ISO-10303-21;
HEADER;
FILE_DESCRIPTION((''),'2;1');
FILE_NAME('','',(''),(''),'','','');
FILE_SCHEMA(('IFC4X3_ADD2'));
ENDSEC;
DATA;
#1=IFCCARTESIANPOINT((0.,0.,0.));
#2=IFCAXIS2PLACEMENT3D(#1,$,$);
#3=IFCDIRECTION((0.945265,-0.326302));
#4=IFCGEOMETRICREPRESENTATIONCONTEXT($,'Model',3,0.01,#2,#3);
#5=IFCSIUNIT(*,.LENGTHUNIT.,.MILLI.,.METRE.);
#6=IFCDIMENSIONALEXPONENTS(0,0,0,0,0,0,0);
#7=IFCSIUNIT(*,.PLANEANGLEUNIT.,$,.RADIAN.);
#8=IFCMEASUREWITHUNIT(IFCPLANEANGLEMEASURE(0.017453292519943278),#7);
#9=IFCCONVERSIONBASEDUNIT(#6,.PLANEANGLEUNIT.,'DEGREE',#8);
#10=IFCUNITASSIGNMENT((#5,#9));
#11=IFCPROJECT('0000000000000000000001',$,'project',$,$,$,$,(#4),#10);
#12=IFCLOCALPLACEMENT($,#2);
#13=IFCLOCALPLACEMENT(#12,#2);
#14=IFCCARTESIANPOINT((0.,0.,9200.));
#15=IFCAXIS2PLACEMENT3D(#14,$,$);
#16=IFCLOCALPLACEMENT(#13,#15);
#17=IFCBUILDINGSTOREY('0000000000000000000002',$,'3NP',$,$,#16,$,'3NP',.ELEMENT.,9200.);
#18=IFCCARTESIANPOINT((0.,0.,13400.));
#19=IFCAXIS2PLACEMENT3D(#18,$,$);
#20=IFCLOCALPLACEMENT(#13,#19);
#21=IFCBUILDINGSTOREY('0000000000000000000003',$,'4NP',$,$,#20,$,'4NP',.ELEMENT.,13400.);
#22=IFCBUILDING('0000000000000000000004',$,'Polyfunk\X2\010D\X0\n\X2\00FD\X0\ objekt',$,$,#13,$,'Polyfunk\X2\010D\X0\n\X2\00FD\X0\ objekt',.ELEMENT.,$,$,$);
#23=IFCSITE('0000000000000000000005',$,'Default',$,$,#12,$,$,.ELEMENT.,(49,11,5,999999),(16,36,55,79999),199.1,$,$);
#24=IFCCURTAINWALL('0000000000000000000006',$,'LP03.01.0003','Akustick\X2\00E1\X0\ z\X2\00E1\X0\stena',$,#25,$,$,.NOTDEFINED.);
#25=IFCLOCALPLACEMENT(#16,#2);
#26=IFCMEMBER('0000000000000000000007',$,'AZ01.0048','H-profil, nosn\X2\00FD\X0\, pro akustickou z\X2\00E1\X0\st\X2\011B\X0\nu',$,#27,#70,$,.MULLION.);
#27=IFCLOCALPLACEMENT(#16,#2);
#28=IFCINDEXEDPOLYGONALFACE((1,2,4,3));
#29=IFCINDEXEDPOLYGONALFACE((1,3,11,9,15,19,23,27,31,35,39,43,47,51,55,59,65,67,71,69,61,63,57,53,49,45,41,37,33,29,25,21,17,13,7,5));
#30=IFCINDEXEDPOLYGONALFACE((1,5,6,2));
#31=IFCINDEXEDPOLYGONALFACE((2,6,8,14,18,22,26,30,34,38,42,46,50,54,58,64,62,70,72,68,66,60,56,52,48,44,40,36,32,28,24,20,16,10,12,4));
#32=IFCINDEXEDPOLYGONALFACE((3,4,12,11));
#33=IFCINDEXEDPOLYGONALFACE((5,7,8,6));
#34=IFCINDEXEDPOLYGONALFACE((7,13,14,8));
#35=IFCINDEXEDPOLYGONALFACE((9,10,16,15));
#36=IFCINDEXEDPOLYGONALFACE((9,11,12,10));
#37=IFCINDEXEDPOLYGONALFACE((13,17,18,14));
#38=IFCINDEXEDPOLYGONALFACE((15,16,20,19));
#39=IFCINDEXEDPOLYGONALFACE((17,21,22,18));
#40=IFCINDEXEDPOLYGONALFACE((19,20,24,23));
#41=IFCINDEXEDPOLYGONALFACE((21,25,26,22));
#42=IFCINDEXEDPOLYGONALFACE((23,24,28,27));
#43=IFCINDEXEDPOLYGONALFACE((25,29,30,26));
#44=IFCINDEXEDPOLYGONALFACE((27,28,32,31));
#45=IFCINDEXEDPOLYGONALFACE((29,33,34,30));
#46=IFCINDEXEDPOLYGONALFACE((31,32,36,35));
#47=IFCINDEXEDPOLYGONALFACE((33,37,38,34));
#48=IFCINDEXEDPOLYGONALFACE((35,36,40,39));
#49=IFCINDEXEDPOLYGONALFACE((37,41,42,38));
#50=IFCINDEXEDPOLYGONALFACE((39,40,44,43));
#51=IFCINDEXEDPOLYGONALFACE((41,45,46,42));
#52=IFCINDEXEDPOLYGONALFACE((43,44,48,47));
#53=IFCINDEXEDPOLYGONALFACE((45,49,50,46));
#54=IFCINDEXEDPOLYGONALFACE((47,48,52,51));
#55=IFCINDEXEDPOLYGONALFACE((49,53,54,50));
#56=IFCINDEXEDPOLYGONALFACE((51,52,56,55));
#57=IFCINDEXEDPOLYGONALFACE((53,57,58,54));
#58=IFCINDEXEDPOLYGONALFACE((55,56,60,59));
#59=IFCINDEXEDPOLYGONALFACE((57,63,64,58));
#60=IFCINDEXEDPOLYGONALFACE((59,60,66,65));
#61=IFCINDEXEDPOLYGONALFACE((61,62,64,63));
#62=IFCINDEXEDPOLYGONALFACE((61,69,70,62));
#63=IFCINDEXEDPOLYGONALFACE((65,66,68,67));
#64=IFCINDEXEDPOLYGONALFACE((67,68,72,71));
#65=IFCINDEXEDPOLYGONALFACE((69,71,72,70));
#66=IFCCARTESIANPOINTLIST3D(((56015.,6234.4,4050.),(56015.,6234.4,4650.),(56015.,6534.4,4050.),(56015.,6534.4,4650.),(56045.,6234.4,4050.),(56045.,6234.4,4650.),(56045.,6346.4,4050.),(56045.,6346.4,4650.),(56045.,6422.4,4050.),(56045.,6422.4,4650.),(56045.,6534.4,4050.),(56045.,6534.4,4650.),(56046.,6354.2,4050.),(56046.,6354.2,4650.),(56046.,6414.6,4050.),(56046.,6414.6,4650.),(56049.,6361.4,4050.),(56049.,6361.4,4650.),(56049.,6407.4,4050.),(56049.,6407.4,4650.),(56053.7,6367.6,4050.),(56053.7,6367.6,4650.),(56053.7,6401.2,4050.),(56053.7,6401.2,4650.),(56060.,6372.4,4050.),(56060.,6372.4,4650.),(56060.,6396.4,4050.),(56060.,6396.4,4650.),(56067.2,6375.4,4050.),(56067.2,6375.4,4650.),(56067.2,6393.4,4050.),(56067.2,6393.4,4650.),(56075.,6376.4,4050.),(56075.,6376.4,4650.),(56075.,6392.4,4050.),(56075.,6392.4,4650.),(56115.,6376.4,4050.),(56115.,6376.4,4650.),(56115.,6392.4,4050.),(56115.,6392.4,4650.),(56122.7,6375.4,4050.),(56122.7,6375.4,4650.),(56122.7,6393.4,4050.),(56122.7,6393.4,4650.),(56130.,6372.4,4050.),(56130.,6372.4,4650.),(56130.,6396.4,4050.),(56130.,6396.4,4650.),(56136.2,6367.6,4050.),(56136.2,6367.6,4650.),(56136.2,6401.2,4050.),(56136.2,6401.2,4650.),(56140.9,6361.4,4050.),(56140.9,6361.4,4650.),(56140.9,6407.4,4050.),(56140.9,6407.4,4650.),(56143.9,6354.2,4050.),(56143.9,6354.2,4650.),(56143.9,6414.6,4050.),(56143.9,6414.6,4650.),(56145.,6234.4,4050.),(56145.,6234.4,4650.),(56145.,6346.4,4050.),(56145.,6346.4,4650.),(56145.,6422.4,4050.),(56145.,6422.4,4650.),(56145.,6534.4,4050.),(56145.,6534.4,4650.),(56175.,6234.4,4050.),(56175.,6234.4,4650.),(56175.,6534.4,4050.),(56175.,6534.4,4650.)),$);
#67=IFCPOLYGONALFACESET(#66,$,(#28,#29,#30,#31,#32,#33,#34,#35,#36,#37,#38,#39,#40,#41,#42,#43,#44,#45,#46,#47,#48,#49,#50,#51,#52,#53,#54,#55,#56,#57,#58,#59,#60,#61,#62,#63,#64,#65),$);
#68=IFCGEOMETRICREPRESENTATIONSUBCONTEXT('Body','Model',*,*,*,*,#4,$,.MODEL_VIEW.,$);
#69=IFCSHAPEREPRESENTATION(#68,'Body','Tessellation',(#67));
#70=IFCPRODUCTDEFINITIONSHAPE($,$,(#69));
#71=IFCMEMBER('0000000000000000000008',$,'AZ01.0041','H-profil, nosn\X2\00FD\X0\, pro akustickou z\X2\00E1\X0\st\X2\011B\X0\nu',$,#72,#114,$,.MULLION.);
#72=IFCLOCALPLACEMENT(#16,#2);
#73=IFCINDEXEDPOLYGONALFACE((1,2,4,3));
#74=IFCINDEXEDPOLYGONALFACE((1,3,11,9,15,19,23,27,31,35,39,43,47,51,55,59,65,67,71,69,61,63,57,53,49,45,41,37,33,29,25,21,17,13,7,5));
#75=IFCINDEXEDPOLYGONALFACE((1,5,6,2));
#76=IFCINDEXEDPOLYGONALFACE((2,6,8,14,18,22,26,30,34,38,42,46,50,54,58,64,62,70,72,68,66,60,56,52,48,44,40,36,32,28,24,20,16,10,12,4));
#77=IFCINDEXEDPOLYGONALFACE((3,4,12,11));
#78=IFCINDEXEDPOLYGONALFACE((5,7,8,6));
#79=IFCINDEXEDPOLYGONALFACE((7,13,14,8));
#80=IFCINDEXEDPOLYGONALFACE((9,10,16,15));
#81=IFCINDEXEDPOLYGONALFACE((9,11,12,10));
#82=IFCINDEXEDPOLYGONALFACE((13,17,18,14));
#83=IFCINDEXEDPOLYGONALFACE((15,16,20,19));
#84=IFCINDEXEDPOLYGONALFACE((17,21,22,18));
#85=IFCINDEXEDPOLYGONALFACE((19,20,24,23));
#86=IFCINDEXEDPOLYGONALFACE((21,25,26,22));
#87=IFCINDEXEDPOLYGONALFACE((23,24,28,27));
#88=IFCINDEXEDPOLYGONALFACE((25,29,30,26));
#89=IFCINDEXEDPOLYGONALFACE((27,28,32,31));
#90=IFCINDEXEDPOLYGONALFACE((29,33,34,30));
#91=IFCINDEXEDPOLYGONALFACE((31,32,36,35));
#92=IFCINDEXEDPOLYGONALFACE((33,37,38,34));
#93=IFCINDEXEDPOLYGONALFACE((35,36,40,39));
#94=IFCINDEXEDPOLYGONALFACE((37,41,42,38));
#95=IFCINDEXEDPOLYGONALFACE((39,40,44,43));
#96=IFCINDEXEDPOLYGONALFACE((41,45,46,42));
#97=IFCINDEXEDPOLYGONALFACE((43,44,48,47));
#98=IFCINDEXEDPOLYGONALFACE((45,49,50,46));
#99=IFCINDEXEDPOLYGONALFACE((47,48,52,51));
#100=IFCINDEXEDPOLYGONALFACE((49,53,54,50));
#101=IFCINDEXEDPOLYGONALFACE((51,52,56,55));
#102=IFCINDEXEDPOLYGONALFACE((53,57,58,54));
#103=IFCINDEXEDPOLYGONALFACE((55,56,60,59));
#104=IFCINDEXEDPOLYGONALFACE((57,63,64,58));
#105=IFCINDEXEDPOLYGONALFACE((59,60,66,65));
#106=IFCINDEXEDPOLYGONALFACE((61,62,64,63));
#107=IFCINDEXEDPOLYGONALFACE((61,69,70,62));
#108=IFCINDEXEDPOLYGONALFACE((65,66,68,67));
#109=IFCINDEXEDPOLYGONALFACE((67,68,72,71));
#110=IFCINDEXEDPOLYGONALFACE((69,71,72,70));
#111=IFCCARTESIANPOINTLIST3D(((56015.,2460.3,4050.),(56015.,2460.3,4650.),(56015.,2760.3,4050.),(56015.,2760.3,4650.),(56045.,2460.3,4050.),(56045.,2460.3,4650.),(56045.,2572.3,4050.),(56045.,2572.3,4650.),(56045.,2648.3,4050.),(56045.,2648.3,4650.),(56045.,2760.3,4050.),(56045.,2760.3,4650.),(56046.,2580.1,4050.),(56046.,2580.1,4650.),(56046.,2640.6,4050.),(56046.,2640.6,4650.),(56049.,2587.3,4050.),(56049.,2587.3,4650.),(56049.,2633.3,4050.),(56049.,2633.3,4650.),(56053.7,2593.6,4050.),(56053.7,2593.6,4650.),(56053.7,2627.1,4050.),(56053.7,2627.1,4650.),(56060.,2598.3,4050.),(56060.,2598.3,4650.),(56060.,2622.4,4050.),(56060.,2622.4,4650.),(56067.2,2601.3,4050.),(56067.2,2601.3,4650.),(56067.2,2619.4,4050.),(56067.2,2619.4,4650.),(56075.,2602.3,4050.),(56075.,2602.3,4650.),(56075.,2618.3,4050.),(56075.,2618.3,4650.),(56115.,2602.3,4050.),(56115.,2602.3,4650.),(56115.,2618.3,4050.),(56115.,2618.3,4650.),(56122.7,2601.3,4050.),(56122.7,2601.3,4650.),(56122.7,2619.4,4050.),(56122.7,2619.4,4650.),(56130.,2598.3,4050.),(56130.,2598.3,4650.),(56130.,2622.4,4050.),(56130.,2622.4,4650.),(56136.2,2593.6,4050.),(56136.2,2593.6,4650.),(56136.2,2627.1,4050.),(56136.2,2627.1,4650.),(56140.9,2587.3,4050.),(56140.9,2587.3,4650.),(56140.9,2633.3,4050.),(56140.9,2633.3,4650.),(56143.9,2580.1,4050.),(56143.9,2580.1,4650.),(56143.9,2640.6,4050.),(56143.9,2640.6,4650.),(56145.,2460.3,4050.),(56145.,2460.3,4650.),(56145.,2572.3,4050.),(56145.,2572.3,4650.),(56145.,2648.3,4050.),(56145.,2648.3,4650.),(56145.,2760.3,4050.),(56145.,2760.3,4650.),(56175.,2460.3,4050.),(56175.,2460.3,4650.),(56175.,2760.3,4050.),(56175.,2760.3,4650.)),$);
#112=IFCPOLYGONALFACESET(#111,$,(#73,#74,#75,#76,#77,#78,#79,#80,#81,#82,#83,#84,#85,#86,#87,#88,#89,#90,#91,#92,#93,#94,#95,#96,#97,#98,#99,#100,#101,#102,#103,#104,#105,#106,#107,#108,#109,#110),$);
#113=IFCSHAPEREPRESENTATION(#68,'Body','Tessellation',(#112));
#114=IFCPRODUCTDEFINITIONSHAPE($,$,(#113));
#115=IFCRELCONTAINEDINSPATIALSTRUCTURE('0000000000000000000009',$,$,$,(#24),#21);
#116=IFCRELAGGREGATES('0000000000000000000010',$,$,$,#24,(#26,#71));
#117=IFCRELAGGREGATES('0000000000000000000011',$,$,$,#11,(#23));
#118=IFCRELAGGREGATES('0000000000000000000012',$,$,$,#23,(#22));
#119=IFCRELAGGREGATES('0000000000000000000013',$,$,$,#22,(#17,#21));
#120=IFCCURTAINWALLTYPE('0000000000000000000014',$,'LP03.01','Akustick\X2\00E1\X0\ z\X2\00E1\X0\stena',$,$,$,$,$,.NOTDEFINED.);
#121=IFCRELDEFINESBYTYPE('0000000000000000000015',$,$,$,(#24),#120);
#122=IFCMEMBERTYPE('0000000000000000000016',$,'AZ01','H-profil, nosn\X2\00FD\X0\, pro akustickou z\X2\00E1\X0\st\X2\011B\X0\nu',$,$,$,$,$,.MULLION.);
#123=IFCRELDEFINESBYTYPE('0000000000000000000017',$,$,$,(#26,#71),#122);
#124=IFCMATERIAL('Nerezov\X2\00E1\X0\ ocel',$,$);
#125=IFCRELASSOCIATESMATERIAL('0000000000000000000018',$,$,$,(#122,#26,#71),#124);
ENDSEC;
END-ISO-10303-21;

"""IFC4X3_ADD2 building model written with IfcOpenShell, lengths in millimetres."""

from ifc_helpers import new_model, entity, si_unit, converted_unit, direction, frame, frame_2d, origin, place, context, subcontext, project, spatial, polyline, circle_curve, parameter, trimmed, segment, composite_curve, outline, extrude, source, transform, mapped, material, material_profile, profile_set, profile_usage, type_object, element, aggregate, save


model = new_model("IFC4X3_ADD2")

# Units and contexts
model_context = context("Model", 3, precision=0.01, world=origin(), true_north=direction((0.945265, -0.326302)))
body_context = subcontext(model_context, "Body", "Model", "MODEL_VIEW")
ifc_project = project(units=[si_unit("LENGTHUNIT", "METRE", prefix="MILLI"), converted_unit("PLANEANGLEUNIT", "DEGREE", entity("IfcPlaneAngleMeasure", 0.017453292519943278), si_unit("PLANEANGLEUNIT", "RADIAN"), dimensions=[0, 0, 0, 0, 0, 0, 0])], contexts=[model_context])

# Site, building, storey
site_placement = place(None, origin())
site = spatial("IfcSite", under=ifc_project, at=site_placement, Name="Default", CompositionType="ELEMENT", RefLatitude=(49, 11, 5, 999999), RefLongitude=(16, 36, 55, 79999), RefElevation=199.1)
building_placement = place(site_placement, origin())
building = spatial("IfcBuilding", under=site, at=building_placement, Name="Polyfunkčný objekt", LongName="Polyfunkčný objekt", CompositionType="ELEMENT")
storey_1_placement = place(building_placement, frame((0.0, 0.0, 9200.0)))
storey_1 = spatial("IfcBuildingStorey", under=building, at=storey_1_placement, Name="3NP", LongName="3NP", CompositionType="ELEMENT", Elevation=9200.0)

# Shared definitions
storey_2_placement = place(building_placement, frame((0.0, 0.0, 13400.0)))
storey_2 = spatial("IfcBuildingStorey", under=building, at=storey_2_placement, Name="4NP", LongName="4NP", CompositionType="ELEMENT", Elevation=13400.0)

# Shared definitions
curtain_wall_type_1 = type_object("IfcCurtainWallType", Name="LP03.01", Description="Akustická zástena", PredefinedType="NOTDEFINED")
ifc_material_1 = material(Name="Nerezová ocel")
ifc_material_profile_1 = material_profile(ifc_material_1, outline(composite_curve([segment(polyline([(50.0, -150.0), (80.0, -150.0)]), True, "CONTINUOUS"), segment(polyline([(80.0, -150.0), (80.0, 150.0)]), True, "CONTINUOUS"), segment(polyline([(80.0, 150.0), (50.0, 150.0)]), True, "CONTINUOUS"), segment(polyline([(50.0, 150.0), (50.0, 38.0)]), True, "CONTINUOUS"), segment(trimmed(circle_curve(frame_2d((20.0, 38.0), x_axis=(0.0, 1.0)), 30.0), [parameter(180.0)], [parameter(270.0)], True, "PARAMETER"), False, "CONTINUOUS"), segment(polyline([(20.0, 8.0), (-20.0, 8.0)]), True, "CONTINUOUS"), segment(trimmed(circle_curve(frame_2d((-20.0, 38.0), x_axis=(0.0, 1.0)), 30.0), [parameter(90.0)], [parameter(180.0)], True, "PARAMETER"), False, "CONTINUOUS"), segment(polyline([(-50.0, 38.0), (-50.0, 150.0)]), True, "CONTINUOUS"), segment(polyline([(-50.0, 150.0), (-80.0, 150.0)]), True, "CONTINUOUS"), segment(polyline([(-80.0, 150.0), (-80.0, -150.0)]), True, "CONTINUOUS"), segment(polyline([(-80.0, -150.0), (-50.0, -150.0)]), True, "CONTINUOUS"), segment(polyline([(-50.0, -150.0), (-50.0, -38.0)]), True, "CONTINUOUS"), segment(trimmed(circle_curve(frame_2d((-20.0, -38.0), x_axis=(0.0, 1.0)), 30.0), [parameter(0.0)], [parameter(90.0)], True, "PARAMETER"), False, "CONTINUOUS"), segment(polyline([(-20.0, -8.0), (20.0, -8.0)]), True, "CONTINUOUS"), segment(trimmed(circle_curve(frame_2d((20.0, -38.0), x_axis=(0.0, 1.0)), 30.0), [parameter(270.0)], [parameter(0.0)], True, "PARAMETER"), False, "CONTINUOUS"), segment(polyline([(50.0, -38.0), (50.0, -150.0)]), True, "CONTINUOUS")], self_intersect=False)), Name="Profil zástena")
ifc_profile_set_1 = profile_set([ifc_material_profile_1], Name="Profil zástena")
ifc_profile_usage_1 = profile_usage(ifc_profile_set_1)
member_type_1 = type_object("IfcMemberType", Name="AZ01", Description="H-profil, nosný, pro akustickou zástěnu", PredefinedType="MULLION", material=ifc_profile_set_1)

# Curtain wall, members
curtain_wall_1_placement = place(storey_2_placement, frame((0.0, 0.0, -13400.0)))
curtain_wall_1 = element("IfcCurtainWall", 1, at=curtain_wall_1_placement, inside=storey_2, type_object=curtain_wall_type_1, Name="LP03.01.0003", Description="Akustická zástena", PredefinedType="NOTDEFINED")
shared_shape_1 = source(origin(), body_context, "Body", "SweptSolid", [
    extrude(outline(composite_curve([segment(polyline([(-150.0, -50.0), (-150.0, -80.0)]), True, "CONTINUOUS"), segment(polyline([(-150.0, -80.0), (150.0, -80.0)]), True, "CONTINUOUS"), segment(polyline([(150.0, -80.0), (150.0, -50.0)]), True, "CONTINUOUS"), segment(polyline([(150.0, -50.0), (38.0, -50.0)]), True, "CONTINUOUS"), segment(trimmed(circle_curve(frame_2d((38.0, -20.0), x_axis=(1.0, 0.0)), 30.0), [parameter(180.0)], [parameter(270.0)], True, "PARAMETER"), False, "CONTINUOUS"), segment(polyline([(8.0, -20.0), (8.0, 20.0)]), True, "CONTINUOUS"), segment(trimmed(circle_curve(frame_2d((38.0, 20.0), x_axis=(1.0, 0.0)), 30.0), [parameter(90.0)], [parameter(180.0)], True, "PARAMETER"), False, "CONTINUOUS"), segment(polyline([(38.0, 50.0), (150.0, 50.0)]), True, "CONTINUOUS"), segment(polyline([(150.0, 50.0), (150.0, 80.0)]), True, "CONTINUOUS"), segment(polyline([(150.0, 80.0), (-150.0, 80.0)]), True, "CONTINUOUS"), segment(polyline([(-150.0, 80.0), (-150.0, 50.0)]), True, "CONTINUOUS"), segment(polyline([(-150.0, 50.0), (-38.0, 50.0)]), True, "CONTINUOUS"), segment(trimmed(circle_curve(frame_2d((-38.0, 20.0), x_axis=(1.0, 0.0)), 30.0), [parameter(0.0)], [parameter(90.0)], True, "PARAMETER"), False, "CONTINUOUS"), segment(polyline([(-8.0, 20.0), (-8.0, -20.0)]), True, "CONTINUOUS"), segment(trimmed(circle_curve(frame_2d((-38.0, -20.0), x_axis=(1.0, 0.0)), 30.0), [parameter(270.0)], [parameter(0.0)], True, "PARAMETER"), False, "CONTINUOUS"), segment(polyline([(-38.0, -50.0), (-150.0, -50.0)]), True, "CONTINUOUS")], self_intersect=False)), frame((-150.0, 0.0, -600.0), z_axis=(0.0, 0.0, -1.0), x_axis=(1.0, 0.0, 0.0)), (0.0, 0.0, -1.0), 600.0),
])
member_1_placement = place(curtain_wall_1_placement, frame((56095.0, 6534.4, 13250.0), z_axis=(0.0, 0.0, -1.0), x_axis=(0.0, 1.0, 0.0)))
member_1 = element("IfcMember", 2, at=member_1_placement, type_object=member_type_1, material=ifc_profile_usage_1, Name="AZ01.0048", Description="H-profil, nosný, pro akustickou zástěnu", PredefinedType="MULLION", context=body_context, shape_type="MappedRepresentation", body=[
    mapped(shared_shape_1, transform((0.0, 0.0, 0.0), scale=1.0)),
])
shared_shape_2 = source(origin(), body_context, "Body", "SweptSolid", [
    extrude(outline(composite_curve([segment(polyline([(-150.0, -50.0), (-150.0, -80.0)]), True, "CONTINUOUS"), segment(polyline([(-150.0, -80.0), (150.0, -80.0)]), True, "CONTINUOUS"), segment(polyline([(150.0, -80.0), (150.0, -50.0)]), True, "CONTINUOUS"), segment(polyline([(150.0, -50.0), (38.0, -50.0)]), True, "CONTINUOUS"), segment(trimmed(circle_curve(frame_2d((38.0, -20.0), x_axis=(1.0, 0.0)), 30.0), [parameter(180.0)], [parameter(270.0)], True, "PARAMETER"), False, "CONTINUOUS"), segment(polyline([(8.0, -20.0), (8.0, 20.0)]), True, "CONTINUOUS"), segment(trimmed(circle_curve(frame_2d((38.0, 20.0), x_axis=(1.0, 0.0)), 30.0), [parameter(90.0)], [parameter(180.0)], True, "PARAMETER"), False, "CONTINUOUS"), segment(polyline([(38.0, 50.0), (150.0, 50.0)]), True, "CONTINUOUS"), segment(polyline([(150.0, 50.0), (150.0, 80.0)]), True, "CONTINUOUS"), segment(polyline([(150.0, 80.0), (-150.0, 80.0)]), True, "CONTINUOUS"), segment(polyline([(-150.0, 80.0), (-150.0, 50.0)]), True, "CONTINUOUS"), segment(polyline([(-150.0, 50.0), (-38.0, 50.0)]), True, "CONTINUOUS"), segment(trimmed(circle_curve(frame_2d((-38.0, 20.0), x_axis=(1.0, 0.0)), 30.0), [parameter(0.0)], [parameter(90.0)], True, "PARAMETER"), False, "CONTINUOUS"), segment(polyline([(-8.0, 20.0), (-8.0, -20.0)]), True, "CONTINUOUS"), segment(trimmed(circle_curve(frame_2d((-38.0, -20.0), x_axis=(1.0, 0.0)), 30.0), [parameter(270.0)], [parameter(0.0)], True, "PARAMETER"), False, "CONTINUOUS"), segment(polyline([(-38.0, -50.0), (-150.0, -50.0)]), True, "CONTINUOUS")], self_intersect=False)), frame((0.0, 0.0, -600.0), z_axis=(0.0, 0.0, -1.0), x_axis=(1.0, 0.0, 0.0)), (0.0, 0.0, -1.0), 600.0),
])
member_2_placement = place(curtain_wall_1_placement, frame((56095.0, 2610.3, 13250.0), z_axis=(0.0, 0.0, -1.0), x_axis=(0.0, 1.0, 0.0)))
member_2 = element("IfcMember", 3, at=member_2_placement, type_object=member_type_1, material=ifc_profile_usage_1, Name="AZ01.0041", Description="H-profil, nosný, pro akustickou zástěnu", PredefinedType="MULLION", context=body_context, shape_type="MappedRepresentation", body=[
    mapped(shared_shape_2, transform((0.0, 0.0, 0.0), scale=1.0)),
])
aggregate(curtain_wall_1, [member_1, member_2])

save(model, "model.ifc")
